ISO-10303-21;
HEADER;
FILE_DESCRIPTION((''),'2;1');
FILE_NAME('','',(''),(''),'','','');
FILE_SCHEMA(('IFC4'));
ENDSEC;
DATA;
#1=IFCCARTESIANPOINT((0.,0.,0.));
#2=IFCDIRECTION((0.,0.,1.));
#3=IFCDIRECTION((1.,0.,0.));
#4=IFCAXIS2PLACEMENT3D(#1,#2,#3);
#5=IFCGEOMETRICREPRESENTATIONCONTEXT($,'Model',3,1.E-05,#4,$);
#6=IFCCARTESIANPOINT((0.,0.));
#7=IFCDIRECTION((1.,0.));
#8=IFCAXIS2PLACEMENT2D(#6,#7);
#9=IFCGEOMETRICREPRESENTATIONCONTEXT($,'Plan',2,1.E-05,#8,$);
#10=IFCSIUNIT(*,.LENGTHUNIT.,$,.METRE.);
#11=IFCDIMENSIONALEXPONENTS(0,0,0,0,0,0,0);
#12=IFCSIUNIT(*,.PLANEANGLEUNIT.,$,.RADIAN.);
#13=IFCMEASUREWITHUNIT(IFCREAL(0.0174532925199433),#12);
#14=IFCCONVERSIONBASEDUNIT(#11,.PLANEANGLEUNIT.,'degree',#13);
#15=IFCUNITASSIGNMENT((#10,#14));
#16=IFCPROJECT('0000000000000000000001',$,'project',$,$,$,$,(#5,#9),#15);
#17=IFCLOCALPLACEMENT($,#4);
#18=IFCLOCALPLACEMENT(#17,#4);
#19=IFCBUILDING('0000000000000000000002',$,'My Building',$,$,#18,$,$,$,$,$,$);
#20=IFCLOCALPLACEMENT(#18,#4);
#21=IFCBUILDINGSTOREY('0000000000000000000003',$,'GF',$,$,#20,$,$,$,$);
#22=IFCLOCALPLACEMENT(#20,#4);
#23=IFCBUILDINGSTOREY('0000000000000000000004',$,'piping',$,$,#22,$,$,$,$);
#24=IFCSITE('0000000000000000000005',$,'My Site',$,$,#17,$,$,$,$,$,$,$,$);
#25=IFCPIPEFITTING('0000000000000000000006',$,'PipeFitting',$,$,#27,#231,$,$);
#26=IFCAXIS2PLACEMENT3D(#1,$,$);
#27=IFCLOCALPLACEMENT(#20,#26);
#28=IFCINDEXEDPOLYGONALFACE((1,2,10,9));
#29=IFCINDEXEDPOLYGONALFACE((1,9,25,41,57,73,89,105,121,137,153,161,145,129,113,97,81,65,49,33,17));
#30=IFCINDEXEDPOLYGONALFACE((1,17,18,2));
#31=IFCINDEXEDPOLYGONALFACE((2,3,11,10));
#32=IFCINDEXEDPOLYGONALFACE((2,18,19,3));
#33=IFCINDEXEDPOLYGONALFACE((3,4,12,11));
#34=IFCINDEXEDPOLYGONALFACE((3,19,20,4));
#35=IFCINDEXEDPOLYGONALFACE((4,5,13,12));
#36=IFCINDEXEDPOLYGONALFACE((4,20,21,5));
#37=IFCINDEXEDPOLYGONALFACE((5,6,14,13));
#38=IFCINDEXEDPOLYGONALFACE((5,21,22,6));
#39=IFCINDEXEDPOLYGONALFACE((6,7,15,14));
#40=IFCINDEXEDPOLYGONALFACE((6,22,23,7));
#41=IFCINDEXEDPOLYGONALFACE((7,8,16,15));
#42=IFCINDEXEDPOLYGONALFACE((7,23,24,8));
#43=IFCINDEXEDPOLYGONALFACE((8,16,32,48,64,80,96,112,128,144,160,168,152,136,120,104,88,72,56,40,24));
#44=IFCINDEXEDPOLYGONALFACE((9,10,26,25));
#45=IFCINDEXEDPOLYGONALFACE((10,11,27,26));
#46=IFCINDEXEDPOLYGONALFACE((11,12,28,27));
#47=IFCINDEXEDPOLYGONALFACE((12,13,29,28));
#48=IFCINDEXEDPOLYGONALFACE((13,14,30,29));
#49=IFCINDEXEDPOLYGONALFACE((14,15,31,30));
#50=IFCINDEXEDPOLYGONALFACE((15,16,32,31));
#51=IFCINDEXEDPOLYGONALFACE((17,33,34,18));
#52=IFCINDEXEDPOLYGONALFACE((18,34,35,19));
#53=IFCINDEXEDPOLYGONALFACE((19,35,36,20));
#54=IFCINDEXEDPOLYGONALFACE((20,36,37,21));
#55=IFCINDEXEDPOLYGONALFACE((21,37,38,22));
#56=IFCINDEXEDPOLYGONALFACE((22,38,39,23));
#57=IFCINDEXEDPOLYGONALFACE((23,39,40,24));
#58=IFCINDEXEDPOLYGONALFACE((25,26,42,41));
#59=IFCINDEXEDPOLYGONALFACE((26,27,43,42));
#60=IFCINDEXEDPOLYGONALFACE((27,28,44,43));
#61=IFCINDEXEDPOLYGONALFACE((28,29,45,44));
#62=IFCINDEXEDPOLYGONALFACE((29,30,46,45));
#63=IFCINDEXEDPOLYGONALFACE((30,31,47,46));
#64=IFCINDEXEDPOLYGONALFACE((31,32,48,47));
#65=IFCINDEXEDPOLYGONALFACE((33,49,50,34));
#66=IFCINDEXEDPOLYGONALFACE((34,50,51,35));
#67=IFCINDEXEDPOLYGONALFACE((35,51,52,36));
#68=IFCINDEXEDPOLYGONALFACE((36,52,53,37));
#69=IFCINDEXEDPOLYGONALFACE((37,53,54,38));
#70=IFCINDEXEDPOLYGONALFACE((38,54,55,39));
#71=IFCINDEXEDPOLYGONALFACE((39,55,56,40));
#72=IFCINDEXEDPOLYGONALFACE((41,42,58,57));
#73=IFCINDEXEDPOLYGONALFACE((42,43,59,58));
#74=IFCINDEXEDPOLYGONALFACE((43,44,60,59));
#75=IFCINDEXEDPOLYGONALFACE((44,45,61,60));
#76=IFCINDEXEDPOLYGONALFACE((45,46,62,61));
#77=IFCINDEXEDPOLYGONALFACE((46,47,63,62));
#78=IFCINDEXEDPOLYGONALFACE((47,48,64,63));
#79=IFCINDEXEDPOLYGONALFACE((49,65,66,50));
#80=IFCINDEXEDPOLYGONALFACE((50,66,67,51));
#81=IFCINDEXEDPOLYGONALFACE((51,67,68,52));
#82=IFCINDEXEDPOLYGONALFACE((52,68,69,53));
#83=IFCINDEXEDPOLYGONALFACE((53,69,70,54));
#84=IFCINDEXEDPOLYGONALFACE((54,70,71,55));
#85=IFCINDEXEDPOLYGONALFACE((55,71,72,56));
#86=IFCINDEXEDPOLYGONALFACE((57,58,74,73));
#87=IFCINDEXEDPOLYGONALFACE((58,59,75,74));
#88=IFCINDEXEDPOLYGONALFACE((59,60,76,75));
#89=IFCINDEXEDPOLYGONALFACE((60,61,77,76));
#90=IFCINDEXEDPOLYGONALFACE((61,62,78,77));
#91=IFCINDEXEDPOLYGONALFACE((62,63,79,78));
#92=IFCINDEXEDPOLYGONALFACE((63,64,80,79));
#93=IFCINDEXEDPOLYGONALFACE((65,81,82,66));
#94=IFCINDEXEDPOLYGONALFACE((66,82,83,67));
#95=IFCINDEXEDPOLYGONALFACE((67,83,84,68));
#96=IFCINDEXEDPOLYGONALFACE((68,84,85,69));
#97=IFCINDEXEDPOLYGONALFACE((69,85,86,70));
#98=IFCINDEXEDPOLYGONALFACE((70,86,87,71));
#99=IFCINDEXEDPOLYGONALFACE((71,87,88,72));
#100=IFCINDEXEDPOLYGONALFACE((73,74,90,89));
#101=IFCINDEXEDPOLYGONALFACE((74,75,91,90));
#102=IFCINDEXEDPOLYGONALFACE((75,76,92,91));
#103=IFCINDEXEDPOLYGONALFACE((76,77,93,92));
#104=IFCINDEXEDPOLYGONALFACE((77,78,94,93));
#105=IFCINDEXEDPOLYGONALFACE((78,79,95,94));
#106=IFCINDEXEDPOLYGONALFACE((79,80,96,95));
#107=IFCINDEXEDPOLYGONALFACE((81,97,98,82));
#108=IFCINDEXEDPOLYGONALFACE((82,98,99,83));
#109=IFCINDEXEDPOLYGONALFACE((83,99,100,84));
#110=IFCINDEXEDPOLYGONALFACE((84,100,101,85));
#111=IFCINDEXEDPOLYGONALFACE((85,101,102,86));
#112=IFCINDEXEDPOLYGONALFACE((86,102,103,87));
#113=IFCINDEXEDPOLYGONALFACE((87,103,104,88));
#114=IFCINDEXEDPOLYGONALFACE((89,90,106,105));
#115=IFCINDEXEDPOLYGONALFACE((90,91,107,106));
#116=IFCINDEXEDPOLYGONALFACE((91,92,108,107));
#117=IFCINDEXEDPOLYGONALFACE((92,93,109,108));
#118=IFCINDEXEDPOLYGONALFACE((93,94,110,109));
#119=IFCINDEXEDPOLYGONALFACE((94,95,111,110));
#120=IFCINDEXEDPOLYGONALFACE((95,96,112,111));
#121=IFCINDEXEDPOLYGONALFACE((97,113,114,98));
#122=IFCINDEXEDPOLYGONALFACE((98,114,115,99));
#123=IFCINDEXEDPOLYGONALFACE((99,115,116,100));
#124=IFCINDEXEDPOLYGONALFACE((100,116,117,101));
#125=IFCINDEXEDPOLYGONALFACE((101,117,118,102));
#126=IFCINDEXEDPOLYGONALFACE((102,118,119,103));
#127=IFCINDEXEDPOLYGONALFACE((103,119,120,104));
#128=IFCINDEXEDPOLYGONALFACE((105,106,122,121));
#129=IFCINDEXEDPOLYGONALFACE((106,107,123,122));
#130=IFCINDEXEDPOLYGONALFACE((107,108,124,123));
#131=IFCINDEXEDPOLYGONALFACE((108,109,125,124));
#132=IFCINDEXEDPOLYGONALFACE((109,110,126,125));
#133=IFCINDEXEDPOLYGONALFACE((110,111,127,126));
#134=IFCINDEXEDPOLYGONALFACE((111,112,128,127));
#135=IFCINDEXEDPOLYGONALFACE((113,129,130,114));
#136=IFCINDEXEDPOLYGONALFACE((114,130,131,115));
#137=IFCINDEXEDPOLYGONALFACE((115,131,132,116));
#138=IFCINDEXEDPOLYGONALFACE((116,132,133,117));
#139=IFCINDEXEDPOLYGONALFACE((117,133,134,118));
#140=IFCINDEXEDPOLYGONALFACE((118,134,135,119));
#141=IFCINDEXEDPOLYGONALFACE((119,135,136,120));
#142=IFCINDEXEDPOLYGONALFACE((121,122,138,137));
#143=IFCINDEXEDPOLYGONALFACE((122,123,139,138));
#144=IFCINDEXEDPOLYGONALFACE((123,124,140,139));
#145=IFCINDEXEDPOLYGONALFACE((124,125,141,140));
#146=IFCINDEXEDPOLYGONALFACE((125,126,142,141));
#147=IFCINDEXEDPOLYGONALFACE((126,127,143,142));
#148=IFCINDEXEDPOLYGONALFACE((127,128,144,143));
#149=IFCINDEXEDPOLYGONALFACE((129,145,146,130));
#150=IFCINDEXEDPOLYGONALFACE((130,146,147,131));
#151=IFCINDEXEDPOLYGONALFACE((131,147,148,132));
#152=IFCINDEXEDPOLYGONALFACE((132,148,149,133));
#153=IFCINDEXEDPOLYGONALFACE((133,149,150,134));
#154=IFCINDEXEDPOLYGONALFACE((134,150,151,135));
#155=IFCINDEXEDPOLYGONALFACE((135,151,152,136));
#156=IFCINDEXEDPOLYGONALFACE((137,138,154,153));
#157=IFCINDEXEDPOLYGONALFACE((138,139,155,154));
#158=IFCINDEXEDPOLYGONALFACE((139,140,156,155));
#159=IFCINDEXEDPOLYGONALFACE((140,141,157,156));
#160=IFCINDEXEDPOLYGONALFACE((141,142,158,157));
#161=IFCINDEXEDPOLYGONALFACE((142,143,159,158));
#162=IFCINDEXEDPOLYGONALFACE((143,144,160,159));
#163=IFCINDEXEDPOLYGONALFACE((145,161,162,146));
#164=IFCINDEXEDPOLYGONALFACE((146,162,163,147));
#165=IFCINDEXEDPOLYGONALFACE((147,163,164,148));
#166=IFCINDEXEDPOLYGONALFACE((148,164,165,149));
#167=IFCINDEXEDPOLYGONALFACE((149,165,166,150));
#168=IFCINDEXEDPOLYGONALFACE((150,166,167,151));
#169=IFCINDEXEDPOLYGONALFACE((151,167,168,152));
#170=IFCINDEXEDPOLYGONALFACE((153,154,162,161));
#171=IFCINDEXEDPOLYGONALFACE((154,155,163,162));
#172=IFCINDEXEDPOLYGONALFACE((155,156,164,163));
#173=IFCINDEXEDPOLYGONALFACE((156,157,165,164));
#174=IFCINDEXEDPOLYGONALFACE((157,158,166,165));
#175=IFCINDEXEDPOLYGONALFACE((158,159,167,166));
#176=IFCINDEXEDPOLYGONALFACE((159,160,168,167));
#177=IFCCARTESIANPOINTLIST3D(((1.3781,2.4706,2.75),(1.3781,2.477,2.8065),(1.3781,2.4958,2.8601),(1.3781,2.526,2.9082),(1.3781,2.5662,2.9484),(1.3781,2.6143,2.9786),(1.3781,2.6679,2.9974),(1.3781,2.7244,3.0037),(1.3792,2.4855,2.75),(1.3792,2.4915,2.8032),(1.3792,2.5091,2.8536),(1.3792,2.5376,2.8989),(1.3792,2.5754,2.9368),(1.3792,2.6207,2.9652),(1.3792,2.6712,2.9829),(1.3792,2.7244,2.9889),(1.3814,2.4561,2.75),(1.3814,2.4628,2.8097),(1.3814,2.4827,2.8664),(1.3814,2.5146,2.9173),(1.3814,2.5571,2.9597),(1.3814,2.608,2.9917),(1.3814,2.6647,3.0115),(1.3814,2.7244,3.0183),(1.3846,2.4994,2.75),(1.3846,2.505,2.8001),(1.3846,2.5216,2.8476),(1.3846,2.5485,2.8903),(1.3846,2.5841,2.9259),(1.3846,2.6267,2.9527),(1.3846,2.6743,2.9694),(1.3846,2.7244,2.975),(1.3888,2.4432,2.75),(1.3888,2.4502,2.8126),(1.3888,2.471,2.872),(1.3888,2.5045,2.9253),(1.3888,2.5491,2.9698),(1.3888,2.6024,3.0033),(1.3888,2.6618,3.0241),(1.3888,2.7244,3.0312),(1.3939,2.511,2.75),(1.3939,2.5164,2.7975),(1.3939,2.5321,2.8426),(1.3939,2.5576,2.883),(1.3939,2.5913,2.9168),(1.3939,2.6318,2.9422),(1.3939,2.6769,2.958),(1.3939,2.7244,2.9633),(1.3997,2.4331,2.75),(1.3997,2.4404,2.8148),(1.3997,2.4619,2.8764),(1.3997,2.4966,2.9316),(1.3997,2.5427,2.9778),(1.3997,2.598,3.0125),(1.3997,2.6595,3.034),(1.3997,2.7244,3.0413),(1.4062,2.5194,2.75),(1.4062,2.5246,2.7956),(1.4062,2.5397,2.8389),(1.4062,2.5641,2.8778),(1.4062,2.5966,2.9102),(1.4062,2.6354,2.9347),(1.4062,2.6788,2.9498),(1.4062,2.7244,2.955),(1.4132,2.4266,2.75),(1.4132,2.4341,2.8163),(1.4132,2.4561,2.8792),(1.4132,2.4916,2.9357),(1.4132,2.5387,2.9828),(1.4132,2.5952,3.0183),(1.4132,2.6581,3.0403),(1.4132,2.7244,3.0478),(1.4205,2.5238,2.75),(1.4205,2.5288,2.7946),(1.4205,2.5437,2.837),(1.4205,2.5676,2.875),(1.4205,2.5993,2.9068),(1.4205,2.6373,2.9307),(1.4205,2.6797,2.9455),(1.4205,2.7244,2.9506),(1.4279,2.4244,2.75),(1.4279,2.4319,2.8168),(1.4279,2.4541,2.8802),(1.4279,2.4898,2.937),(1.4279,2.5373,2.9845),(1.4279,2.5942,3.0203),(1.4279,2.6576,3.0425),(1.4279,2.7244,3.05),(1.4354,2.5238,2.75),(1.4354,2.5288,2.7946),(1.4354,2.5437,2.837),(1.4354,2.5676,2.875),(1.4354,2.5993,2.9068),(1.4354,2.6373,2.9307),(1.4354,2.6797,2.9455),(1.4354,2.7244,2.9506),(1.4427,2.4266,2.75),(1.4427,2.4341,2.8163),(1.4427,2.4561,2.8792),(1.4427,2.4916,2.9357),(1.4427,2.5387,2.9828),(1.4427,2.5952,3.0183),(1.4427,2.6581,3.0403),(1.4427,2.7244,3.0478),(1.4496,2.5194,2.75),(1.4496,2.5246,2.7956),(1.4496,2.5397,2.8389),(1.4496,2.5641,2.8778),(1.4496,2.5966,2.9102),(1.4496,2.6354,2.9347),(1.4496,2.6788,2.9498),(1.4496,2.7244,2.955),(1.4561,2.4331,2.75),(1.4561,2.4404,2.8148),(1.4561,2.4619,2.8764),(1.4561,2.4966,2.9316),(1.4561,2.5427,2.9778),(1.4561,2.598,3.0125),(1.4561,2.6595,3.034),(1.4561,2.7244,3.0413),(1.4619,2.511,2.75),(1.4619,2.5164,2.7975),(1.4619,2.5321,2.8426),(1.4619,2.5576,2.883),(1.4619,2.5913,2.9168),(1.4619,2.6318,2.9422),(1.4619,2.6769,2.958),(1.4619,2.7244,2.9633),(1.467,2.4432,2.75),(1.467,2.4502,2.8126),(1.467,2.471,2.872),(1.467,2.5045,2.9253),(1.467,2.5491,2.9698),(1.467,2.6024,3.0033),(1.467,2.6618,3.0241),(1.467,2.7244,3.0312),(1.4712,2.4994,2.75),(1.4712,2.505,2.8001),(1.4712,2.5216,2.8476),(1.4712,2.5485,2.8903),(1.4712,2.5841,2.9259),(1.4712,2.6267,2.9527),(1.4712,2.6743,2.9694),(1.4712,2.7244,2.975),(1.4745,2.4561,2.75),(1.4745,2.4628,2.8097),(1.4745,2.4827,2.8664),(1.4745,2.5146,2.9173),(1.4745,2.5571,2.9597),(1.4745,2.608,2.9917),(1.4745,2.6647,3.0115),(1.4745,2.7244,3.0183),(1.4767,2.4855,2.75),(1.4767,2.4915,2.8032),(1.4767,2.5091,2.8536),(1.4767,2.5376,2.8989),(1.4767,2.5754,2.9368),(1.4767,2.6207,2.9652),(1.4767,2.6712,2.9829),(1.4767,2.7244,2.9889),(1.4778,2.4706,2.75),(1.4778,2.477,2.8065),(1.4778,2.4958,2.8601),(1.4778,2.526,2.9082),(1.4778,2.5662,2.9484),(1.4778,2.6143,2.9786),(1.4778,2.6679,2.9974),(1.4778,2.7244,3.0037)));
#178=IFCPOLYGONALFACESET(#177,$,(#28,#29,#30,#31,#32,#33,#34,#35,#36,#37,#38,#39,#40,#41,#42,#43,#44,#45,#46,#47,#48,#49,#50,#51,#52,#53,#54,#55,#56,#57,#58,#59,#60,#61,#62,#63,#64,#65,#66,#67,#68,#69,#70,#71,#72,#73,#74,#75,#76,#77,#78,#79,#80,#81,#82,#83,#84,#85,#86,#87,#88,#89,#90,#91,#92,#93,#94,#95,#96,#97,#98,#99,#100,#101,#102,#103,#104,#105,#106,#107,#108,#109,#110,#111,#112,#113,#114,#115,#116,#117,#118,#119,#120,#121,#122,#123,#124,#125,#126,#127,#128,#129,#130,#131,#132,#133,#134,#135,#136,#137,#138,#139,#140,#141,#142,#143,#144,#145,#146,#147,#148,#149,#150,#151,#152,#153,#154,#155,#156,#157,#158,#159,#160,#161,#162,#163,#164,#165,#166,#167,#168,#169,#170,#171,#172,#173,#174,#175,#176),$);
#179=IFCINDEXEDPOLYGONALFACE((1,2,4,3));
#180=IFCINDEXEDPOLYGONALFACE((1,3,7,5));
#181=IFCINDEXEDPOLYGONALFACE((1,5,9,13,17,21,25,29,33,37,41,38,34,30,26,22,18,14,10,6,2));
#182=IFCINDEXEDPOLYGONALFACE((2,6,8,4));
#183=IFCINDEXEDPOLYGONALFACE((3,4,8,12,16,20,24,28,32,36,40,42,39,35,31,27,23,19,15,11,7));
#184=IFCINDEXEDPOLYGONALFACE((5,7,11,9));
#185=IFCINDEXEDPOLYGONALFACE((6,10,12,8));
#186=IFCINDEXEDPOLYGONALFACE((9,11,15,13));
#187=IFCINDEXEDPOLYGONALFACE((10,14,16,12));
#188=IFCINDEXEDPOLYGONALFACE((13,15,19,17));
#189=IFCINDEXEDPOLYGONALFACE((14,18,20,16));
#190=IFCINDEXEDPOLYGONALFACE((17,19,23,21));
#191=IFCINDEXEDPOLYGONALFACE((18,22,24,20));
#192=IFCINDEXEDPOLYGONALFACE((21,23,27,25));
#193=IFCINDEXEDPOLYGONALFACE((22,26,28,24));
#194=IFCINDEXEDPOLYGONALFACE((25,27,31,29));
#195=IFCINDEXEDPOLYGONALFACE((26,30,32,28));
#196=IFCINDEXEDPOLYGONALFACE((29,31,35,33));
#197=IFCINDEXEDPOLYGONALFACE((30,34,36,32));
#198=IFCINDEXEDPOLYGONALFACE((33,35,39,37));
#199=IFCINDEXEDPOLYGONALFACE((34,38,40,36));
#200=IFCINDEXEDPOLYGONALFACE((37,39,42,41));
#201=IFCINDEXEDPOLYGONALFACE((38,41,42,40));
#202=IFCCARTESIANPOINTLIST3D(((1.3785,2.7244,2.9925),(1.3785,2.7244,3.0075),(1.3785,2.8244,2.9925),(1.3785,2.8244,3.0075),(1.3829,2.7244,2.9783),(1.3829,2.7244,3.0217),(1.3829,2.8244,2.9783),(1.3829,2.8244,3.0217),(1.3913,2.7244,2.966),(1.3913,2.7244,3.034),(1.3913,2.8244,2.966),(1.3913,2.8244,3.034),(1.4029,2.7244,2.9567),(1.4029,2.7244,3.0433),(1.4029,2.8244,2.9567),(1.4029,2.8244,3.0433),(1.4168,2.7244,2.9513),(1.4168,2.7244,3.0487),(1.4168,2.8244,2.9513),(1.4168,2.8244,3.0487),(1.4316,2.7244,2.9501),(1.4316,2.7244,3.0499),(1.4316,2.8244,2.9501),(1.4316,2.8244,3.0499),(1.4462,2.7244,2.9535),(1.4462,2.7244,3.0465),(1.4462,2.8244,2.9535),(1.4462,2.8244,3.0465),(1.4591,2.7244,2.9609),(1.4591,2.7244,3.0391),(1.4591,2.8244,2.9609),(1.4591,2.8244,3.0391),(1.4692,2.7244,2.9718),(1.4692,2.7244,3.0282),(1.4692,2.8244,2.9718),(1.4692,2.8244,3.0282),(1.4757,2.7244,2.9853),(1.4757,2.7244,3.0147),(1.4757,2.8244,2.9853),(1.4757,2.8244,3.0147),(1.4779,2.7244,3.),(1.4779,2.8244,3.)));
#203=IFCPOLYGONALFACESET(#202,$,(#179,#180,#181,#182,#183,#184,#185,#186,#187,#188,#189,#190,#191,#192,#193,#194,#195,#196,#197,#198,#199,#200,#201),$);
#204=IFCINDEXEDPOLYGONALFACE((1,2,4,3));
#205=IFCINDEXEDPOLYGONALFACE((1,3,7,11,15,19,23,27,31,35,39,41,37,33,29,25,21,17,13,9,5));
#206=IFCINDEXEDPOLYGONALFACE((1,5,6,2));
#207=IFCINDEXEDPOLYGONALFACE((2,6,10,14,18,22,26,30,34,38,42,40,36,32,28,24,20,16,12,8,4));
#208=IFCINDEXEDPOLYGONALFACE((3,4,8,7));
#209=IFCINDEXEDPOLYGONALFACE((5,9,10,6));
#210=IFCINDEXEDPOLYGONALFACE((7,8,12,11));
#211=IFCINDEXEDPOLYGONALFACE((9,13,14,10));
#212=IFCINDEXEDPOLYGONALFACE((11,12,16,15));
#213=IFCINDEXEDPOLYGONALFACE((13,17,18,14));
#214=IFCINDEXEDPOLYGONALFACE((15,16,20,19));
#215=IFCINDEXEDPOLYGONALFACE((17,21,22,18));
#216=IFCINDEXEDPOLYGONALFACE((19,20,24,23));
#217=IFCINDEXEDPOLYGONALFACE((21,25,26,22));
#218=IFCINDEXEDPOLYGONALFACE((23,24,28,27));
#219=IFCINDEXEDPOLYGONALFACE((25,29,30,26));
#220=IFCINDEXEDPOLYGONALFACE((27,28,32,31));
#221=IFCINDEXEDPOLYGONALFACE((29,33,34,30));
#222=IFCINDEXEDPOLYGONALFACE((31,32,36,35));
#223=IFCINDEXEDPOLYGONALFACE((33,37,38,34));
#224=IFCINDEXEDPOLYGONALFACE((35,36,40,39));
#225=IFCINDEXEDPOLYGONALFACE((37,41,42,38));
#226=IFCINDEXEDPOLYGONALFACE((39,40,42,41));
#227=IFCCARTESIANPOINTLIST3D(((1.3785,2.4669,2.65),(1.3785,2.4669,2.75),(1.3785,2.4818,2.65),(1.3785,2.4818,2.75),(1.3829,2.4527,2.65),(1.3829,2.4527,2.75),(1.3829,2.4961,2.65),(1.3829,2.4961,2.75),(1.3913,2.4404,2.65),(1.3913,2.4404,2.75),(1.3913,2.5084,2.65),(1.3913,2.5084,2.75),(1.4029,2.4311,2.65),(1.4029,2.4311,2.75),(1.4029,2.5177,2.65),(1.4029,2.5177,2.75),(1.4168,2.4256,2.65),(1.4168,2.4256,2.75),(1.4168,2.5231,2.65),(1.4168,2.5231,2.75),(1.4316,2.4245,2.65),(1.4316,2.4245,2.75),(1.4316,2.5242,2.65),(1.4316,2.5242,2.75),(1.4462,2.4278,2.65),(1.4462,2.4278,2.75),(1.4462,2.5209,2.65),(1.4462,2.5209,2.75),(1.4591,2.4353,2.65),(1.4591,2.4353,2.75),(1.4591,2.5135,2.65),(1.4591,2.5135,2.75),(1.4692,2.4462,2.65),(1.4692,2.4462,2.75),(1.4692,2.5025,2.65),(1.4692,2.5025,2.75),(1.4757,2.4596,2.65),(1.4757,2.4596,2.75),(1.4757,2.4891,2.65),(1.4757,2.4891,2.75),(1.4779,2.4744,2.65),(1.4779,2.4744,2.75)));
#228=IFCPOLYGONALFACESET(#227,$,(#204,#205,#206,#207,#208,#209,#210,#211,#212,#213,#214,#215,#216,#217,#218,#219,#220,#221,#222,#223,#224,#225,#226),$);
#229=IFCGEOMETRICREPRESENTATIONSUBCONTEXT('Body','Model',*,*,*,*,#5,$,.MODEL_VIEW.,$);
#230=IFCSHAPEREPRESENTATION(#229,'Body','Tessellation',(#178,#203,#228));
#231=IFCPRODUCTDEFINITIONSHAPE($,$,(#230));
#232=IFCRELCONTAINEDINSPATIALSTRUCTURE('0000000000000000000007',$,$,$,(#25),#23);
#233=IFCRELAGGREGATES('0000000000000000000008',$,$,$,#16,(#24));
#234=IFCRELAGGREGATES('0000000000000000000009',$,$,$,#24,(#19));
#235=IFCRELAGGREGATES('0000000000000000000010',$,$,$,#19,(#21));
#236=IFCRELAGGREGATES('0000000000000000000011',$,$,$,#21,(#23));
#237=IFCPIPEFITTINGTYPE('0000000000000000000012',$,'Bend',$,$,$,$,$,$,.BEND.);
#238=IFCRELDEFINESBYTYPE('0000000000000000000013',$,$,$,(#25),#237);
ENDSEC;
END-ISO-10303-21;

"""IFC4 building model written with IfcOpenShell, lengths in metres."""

from ifc_helpers import new_model, entity, si_unit, converted_unit, frame, origin_with_axes, origin_2d_with_axis, place, context, subcontext, project, spatial, circle, extrude, source, transform, mapped, type_object, type_shapes, element, save


model = new_model("IFC4")

# Units and contexts
model_context = context("Model", 3, precision=1e-05, world=origin_with_axes())
plan_context = context("Plan", 2, precision=1e-05, world=origin_2d_with_axis())
body_context = subcontext(model_context, "Body", "Model", "MODEL_VIEW")
ifc_project = project(units=[si_unit("LENGTHUNIT", "METRE"), converted_unit("PLANEANGLEUNIT", "degree", entity("IfcReal", 0.0174532925199433), si_unit("PLANEANGLEUNIT", "RADIAN"), dimensions=[0, 0, 0, 0, 0, 0, 0])], contexts=[model_context, plan_context])

# Site, building, storeys
site_placement = place(None, origin_with_axes())
site = spatial("IfcSite", under=ifc_project, at=site_placement, Name="My Site")
building_placement = place(site_placement, origin_with_axes())
building = spatial("IfcBuilding", under=site, at=building_placement, Name="My Building")
storey_1_placement = place(building_placement, origin_with_axes())
storey_1 = spatial("IfcBuildingStorey", under=building, at=storey_1_placement, Name="GF")
storey_2_placement = place(storey_1_placement, origin_with_axes())
storey_2 = spatial("IfcBuildingStorey", under=storey_1, at=storey_2_placement, Name="piping")

# Pipe fitting
pipe_fitting_type = type_object("IfcPipeFittingType", Name="Bend", PredefinedType="BEND")
shared_shape = source(origin_with_axes(), body_context, "Body", "SolidModel", [
    entity("IfcSweptDiskSolid", entity("IfcIndexedPolyCurve", entity("IfcCartesianPointList3D", [[0.0, 0.0, 0.1], [0.0, -0.0732, 0.2768], [0.0, -0.25, 0.35]]), [entity("IfcArcIndex", [1, 2, 3])]), 0.05),
    extrude(circle(Radius=0.05), origin_with_axes(), (0.0, 0.0, 1.0), 0.1),
    extrude(circle(Radius=0.05), frame((0.0, -0.25, 0.35), z_axis=(0.0, -1.0, 0.0), x_axis=(1.0, 0.0, 0.0)), (0.0, 0.0, 1.0), 0.1),
])
type_shapes(pipe_fitting_type, [shared_shape])
for number, where, z_axis, x_axis, name in (
    (1, (1.4279, 2.8244, 3.0), (0.0, -1.0, 0.0), (1.0, 0.0, 0.0), "PipeFitting"),
):
    element("IfcPipeFitting", number, at=place(storey_2_placement, frame(where, z_axis=z_axis, x_axis=x_axis)), inside=storey_2, type_object=pipe_fitting_type, Name=name, context=body_context, shape_type="MappedRepresentation", body=[
        mapped(shared_shape, transform((0.0, 0.0, 0.0), x_axis=(1.0, 0.0, 0.0), y_axis=(0.0, 1.0, 0.0), z_axis=(0.0, 0.0, 1.0), scale=1.0)),
    ])

save(model, "model.ifc")
